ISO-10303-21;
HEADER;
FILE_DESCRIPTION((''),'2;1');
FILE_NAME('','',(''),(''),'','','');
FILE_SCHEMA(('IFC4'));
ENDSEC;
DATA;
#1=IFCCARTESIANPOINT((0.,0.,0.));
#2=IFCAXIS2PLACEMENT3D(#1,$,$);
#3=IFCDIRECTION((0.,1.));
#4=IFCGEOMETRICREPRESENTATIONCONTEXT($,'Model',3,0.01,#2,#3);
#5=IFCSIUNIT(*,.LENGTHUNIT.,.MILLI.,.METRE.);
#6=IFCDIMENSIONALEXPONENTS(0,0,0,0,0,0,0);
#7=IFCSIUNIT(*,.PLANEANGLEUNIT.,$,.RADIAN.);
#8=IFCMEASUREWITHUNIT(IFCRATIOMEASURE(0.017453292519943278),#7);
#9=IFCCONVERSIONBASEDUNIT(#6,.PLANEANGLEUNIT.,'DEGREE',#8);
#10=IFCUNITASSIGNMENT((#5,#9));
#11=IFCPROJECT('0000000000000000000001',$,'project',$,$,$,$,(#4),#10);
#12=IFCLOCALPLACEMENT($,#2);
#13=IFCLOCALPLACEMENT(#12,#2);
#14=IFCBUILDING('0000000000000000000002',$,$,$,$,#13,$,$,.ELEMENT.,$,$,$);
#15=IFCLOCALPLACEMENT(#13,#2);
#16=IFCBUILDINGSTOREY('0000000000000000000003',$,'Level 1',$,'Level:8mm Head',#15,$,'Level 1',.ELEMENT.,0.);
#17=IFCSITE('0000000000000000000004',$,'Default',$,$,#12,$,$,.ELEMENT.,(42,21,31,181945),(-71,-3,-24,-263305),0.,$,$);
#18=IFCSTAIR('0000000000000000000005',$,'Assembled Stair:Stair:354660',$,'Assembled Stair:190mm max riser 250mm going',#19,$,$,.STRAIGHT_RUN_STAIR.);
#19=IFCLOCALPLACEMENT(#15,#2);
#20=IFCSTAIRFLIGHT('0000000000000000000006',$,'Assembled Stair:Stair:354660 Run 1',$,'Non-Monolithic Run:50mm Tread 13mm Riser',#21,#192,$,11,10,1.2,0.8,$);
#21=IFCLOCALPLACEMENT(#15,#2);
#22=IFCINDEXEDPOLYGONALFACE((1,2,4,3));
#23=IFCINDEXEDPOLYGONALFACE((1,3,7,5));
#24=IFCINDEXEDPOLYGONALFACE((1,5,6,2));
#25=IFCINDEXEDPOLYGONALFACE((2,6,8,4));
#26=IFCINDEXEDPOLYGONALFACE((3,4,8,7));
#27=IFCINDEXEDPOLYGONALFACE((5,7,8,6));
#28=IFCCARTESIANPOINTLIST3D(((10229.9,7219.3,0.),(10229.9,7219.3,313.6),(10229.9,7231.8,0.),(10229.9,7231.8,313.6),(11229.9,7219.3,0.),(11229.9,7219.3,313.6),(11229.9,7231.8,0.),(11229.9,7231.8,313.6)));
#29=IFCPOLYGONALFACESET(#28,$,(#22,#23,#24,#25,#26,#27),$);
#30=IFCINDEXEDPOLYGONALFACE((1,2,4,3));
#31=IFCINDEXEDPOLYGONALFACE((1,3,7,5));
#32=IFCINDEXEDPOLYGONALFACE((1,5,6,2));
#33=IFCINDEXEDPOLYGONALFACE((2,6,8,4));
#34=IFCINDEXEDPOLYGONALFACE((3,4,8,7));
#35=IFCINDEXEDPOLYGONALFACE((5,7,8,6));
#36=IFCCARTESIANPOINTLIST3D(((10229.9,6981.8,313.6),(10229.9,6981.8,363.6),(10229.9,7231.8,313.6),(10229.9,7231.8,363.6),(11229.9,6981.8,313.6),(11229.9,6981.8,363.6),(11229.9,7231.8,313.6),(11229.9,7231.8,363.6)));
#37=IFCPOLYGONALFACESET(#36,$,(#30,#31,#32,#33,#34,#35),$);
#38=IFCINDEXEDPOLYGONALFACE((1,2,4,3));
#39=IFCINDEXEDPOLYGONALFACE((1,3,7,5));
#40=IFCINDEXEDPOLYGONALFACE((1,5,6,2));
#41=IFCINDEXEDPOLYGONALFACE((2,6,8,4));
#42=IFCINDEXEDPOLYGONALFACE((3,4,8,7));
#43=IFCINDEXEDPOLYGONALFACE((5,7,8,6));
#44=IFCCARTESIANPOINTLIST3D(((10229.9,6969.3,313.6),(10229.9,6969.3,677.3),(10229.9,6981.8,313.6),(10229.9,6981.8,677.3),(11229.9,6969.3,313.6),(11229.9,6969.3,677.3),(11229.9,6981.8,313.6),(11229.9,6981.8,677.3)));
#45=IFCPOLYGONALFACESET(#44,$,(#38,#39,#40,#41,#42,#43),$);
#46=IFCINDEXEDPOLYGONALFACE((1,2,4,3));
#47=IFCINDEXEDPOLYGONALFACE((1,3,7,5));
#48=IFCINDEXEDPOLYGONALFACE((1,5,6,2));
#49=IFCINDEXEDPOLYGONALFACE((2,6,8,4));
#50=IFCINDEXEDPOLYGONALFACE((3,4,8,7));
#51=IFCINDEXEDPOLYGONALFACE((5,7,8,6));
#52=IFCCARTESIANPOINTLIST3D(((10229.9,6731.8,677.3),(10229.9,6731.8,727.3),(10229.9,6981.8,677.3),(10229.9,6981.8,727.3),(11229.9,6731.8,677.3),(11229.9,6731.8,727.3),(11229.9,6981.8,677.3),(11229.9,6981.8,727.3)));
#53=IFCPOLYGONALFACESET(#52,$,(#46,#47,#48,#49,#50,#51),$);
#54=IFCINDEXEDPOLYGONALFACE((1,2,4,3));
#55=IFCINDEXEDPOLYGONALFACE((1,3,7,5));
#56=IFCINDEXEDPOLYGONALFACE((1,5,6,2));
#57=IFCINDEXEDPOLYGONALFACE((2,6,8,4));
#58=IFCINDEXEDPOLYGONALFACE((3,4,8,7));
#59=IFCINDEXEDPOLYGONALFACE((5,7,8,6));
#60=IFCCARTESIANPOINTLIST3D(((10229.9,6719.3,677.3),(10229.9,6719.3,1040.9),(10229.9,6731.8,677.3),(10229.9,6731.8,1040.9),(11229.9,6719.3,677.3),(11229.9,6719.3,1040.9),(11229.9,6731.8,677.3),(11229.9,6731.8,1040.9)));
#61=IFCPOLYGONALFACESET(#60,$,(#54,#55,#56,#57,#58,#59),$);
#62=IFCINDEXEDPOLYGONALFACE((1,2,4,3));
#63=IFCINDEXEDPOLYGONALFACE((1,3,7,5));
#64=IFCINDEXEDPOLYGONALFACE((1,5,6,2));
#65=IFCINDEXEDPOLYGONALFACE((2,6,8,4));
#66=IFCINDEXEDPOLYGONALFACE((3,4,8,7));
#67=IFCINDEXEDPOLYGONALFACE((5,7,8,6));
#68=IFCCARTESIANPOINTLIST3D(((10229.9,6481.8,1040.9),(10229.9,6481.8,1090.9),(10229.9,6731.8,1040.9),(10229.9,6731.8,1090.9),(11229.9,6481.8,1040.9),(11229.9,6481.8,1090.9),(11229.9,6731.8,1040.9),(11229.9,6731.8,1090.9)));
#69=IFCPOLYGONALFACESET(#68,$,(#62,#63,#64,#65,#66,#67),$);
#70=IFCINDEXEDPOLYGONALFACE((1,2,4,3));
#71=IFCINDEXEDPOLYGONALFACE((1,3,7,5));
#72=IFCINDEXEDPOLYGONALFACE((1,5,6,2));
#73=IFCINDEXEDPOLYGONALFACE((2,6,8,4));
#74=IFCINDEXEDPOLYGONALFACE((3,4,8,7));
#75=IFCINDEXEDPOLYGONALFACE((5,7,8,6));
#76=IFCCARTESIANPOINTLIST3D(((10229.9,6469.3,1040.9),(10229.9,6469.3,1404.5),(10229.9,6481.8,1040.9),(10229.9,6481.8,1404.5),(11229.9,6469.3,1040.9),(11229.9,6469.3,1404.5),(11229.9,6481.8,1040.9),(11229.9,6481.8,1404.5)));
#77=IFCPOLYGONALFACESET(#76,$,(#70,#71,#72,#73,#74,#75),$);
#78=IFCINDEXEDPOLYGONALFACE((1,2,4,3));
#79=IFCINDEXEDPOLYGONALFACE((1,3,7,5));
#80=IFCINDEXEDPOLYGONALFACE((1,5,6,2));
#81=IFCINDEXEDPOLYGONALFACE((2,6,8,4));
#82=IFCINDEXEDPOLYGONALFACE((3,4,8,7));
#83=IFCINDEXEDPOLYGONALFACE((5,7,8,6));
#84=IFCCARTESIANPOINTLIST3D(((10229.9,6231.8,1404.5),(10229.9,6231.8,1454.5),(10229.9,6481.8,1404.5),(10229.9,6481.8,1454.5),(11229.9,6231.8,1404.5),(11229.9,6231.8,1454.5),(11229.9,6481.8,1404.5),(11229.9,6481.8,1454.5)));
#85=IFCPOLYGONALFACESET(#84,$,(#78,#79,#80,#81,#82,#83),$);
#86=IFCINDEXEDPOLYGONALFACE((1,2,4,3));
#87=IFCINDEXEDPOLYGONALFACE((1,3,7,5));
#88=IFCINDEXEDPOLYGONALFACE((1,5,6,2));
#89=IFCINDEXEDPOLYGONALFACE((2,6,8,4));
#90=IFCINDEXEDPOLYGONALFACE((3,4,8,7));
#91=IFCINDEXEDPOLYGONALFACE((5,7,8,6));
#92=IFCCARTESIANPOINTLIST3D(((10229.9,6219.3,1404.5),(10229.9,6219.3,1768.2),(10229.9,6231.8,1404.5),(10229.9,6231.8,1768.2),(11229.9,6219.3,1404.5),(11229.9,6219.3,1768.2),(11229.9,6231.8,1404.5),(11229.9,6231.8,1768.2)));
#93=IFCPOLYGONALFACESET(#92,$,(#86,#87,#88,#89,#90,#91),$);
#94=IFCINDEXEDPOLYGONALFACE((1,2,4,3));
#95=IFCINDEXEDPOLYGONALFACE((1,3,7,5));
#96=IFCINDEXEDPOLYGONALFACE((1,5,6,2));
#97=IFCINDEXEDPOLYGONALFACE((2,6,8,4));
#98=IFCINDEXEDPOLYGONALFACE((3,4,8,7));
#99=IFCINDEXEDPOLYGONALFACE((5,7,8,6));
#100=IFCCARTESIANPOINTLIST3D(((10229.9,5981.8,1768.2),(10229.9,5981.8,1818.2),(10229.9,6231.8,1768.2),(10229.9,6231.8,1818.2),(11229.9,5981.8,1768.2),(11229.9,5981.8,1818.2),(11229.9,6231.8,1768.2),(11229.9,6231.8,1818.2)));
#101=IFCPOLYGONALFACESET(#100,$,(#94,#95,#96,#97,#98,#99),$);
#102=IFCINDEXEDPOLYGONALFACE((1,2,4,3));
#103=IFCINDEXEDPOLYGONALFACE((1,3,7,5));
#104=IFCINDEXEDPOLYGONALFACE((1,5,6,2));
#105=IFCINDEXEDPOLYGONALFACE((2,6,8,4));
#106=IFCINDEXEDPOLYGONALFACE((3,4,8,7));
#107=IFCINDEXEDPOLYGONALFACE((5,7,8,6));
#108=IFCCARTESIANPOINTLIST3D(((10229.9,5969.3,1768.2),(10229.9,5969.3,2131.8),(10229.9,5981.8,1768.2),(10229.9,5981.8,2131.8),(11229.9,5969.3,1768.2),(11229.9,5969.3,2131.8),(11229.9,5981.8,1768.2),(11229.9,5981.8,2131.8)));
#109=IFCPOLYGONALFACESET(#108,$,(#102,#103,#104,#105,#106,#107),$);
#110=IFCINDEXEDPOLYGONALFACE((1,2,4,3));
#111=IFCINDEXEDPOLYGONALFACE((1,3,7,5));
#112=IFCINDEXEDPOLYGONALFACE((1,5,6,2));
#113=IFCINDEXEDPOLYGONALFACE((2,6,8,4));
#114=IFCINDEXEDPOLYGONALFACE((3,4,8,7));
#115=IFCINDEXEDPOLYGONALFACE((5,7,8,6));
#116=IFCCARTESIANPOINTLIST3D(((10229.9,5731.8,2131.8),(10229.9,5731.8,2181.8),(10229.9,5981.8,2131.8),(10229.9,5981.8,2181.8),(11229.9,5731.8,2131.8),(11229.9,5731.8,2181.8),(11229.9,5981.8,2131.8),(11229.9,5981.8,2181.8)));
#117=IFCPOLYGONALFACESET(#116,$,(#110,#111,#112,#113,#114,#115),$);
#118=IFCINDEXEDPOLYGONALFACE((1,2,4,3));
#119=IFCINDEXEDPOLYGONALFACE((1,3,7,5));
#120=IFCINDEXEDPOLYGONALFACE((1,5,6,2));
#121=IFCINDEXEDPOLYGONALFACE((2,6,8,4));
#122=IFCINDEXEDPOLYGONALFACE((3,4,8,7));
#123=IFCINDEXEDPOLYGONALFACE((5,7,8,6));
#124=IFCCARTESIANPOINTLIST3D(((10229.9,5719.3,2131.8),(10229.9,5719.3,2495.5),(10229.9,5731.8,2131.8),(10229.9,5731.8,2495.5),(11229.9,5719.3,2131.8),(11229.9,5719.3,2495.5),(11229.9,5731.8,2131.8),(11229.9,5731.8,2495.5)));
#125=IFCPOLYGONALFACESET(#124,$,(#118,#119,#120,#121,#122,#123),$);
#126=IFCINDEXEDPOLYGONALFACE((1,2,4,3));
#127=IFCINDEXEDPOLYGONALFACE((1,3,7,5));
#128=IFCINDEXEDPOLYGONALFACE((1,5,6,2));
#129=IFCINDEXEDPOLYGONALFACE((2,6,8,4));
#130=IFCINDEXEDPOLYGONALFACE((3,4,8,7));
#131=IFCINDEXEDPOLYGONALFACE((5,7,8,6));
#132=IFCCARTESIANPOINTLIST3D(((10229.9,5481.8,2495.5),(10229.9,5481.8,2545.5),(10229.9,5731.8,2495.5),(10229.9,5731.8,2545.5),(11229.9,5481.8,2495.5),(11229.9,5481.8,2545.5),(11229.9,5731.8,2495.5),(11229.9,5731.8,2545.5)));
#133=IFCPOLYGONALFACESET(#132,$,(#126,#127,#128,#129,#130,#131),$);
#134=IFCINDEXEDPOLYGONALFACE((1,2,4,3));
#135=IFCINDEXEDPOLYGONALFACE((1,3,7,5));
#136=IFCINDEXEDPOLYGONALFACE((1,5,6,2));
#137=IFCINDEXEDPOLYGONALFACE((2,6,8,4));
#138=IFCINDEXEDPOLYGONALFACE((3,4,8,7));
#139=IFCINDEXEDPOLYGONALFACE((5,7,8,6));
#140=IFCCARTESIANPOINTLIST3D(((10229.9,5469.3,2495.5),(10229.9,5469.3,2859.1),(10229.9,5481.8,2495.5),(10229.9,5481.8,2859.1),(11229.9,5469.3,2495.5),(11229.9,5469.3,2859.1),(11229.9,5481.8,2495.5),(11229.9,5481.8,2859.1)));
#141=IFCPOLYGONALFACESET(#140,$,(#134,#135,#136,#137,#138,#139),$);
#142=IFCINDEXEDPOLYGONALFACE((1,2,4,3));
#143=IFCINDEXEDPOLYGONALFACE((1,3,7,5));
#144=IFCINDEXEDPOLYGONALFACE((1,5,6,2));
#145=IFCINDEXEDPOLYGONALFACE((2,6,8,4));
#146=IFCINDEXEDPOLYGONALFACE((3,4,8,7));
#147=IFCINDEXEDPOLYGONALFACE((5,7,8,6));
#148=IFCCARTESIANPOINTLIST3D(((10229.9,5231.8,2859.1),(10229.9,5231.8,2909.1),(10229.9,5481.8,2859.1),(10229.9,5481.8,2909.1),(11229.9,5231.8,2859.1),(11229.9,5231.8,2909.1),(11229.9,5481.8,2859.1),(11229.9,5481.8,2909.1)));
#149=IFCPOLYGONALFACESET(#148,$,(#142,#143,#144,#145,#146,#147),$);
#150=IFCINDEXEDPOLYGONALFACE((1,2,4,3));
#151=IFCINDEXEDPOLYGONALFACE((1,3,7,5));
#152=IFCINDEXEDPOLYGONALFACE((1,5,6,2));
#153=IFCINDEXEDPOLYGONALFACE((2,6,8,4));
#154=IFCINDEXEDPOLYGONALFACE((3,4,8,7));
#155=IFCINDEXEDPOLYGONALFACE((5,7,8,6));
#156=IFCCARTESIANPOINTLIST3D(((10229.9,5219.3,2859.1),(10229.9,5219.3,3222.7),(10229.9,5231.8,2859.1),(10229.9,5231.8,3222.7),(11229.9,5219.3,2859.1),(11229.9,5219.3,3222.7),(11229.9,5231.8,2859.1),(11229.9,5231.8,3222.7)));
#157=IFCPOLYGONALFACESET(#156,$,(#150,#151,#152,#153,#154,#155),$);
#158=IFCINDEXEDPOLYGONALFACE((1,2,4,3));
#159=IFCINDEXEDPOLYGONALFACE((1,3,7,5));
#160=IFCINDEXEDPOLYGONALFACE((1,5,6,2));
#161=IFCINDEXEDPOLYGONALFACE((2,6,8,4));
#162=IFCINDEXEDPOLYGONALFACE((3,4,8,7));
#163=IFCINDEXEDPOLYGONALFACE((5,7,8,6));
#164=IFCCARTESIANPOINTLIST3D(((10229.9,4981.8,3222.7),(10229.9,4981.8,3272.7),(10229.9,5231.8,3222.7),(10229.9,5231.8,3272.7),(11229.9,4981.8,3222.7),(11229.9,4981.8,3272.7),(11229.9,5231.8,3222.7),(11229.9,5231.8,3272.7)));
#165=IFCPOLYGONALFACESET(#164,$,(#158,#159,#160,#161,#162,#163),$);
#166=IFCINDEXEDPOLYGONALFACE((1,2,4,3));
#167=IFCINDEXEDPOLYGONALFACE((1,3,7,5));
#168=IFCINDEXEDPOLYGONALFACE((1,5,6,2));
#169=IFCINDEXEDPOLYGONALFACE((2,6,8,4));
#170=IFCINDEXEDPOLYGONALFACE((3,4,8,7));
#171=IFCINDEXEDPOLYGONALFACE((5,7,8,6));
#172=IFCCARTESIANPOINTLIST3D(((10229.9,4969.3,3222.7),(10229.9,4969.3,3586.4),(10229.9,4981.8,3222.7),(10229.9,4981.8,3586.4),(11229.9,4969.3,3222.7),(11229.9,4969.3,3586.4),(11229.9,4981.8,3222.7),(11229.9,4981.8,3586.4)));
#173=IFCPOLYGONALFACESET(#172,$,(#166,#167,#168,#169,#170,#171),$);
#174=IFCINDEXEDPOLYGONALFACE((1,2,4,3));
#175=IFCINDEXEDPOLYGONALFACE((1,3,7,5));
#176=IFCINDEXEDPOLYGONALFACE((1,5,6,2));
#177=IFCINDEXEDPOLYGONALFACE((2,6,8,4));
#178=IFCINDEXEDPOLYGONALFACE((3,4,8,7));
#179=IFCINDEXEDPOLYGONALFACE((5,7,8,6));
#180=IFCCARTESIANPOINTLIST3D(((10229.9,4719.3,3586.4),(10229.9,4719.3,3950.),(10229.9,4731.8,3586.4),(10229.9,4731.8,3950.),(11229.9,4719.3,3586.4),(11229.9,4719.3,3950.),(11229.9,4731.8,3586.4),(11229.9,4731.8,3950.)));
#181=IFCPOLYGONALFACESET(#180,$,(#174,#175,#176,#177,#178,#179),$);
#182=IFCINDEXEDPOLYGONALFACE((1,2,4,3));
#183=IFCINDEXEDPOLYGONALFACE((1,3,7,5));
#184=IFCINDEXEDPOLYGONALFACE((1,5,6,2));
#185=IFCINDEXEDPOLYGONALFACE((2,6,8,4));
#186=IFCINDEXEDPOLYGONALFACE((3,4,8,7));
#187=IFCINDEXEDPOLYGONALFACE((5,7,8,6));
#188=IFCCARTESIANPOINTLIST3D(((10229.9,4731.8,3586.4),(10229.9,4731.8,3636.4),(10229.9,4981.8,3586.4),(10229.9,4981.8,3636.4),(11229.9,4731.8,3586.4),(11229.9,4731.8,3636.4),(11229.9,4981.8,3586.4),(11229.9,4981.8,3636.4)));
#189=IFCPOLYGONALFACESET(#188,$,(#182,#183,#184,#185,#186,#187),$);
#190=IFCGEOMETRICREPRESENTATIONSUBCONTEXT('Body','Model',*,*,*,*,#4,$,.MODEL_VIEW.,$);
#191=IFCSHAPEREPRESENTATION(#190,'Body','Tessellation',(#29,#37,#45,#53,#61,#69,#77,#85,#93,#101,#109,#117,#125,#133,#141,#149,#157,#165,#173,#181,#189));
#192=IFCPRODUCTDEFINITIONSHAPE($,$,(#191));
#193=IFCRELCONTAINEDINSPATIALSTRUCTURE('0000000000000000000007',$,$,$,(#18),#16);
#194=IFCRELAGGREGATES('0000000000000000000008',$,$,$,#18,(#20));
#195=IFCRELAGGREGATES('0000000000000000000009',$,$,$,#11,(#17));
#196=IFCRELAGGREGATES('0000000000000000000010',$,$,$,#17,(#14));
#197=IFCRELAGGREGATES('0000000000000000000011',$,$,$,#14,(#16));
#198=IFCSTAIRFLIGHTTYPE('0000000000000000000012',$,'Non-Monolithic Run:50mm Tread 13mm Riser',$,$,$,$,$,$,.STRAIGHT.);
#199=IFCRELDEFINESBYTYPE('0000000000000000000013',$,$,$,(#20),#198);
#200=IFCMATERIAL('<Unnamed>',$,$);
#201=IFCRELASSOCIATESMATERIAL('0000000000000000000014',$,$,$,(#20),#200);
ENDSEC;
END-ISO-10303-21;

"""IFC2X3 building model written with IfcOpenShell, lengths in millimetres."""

from ifc_helpers import new_model, entity, si_unit, converted_unit, direction, frame, frame_2d, origin, origin_2d_with_axis, place, context, subcontext, project, spatial, rectangle, extrude, material, type_object, element, aggregate, save


model = new_model("IFC2X3")

# Units and contexts
model_context = context("Model", 3, precision=0.01, world=origin(), true_north=direction((0.0, 1.0)))
body_context = subcontext(model_context, "Body", "Model", "MODEL_VIEW")
ifc_project = project(units=[si_unit("LENGTHUNIT", "METRE", prefix="MILLI"), converted_unit("PLANEANGLEUNIT", "DEGREE", entity("IfcRatioMeasure", 0.017453292519943278), si_unit("PLANEANGLEUNIT", "RADIAN"), dimensions=[0, 0, 0, 0, 0, 0, 0])], contexts=[model_context])

# Site, building, storey
site_placement = place(None, origin())
site = spatial("IfcSite", under=ifc_project, at=site_placement, Name="Default", CompositionType="ELEMENT", RefLatitude=(42, 21, 31, 181945), RefLongitude=(-71, -3, -24, -263305), RefElevation=0.0)
building_placement = place(site_placement, origin())
building = spatial("IfcBuilding", under=site, at=building_placement, CompositionType="ELEMENT")
storey_placement = place(building_placement, origin())
storey = spatial("IfcBuildingStorey", under=building, at=storey_placement, Name="Level 1", ObjectType="Level:8mm Head", LongName="Level 1", CompositionType="ELEMENT", Elevation=0.0)

# Stair
stair_placement = place(storey_placement, origin())
stair = element("IfcStair", 1, at=stair_placement, inside=storey, Name="Assembled Stair:Stair:354660", ObjectType="Assembled Stair:190mm max riser 250mm going", ShapeType="STRAIGHT_RUN_STAIR")
ifc_material_1 = material(Name="<Unnamed>")

# Stair flight
stair_flight_type = type_object("IfcStairFlightType", Name="Non-Monolithic Run:50mm Tread 13mm Riser", PredefinedType="STRAIGHT")
stair_flight_placement = place(stair_placement, origin())
stair_flight = element("IfcStairFlight", 2, at=stair_flight_placement, type_object=stair_flight_type, material=ifc_material_1, Name="Assembled Stair:Stair:354660 Run 1", ObjectType="Non-Monolithic Run:50mm Tread 13mm Riser", NumberOfRiser=11, NumberOfTreads=10, RiserHeight=1.2, TreadLength=0.8, context=body_context, shape_type="SweptSolid", body=[
    extrude(rectangle(XDim=1000.0, YDim=12.5, at=frame_2d((0.0, 0.0), x_axis=(1.0, 0.0))), frame((10729.9, 7225.6, 0.0)), (0.0, 0.0, 1.0), 313.6),
    extrude(rectangle(XDim=250.0, YDim=1000.0, at=origin_2d_with_axis()), frame((10729.9, 7106.8, 313.6), z_axis=(0.0, 0.0, 1.0), x_axis=(0.0, 1.0, 0.0)), (0.0, 0.0, 1.0), 50.0),
    extrude(rectangle(XDim=1000.0, YDim=12.5, at=frame_2d((0.0, 0.0), x_axis=(1.0, 0.0))), frame((10729.9, 6975.6, 313.6)), (0.0, 0.0, 1.0), 363.6),
    extrude(rectangle(XDim=250.0, YDim=1000.0, at=frame_2d((0.0, 0.0), x_axis=(1.0, 0.0))), frame((10729.9, 6856.8, 677.3), z_axis=(0.0, 0.0, 1.0), x_axis=(0.0, 1.0, 0.0)), (0.0, 0.0, 1.0), 50.0),
    extrude(rectangle(XDim=1000.0, YDim=12.5, at=frame_2d((0.0, 0.0), x_axis=(1.0, 0.0))), frame((10729.9, 6725.6, 677.3)), (0.0, 0.0, 1.0), 363.6),
    extrude(rectangle(XDim=250.0, YDim=1000.0, at=frame_2d((0.0, 0.0), x_axis=(1.0, 0.0))), frame((10729.9, 6606.8, 1040.9), z_axis=(0.0, 0.0, 1.0), x_axis=(0.0, 1.0, 0.0)), (0.0, 0.0, 1.0), 50.0),
    extrude(rectangle(XDim=1000.0, YDim=12.5, at=frame_2d((0.0, 0.0), x_axis=(1.0, 0.0))), frame((10729.9, 6475.6, 1040.9)), (0.0, 0.0, 1.0), 363.6),
    extrude(rectangle(XDim=250.0, YDim=1000.0, at=frame_2d((0.0, 0.0), x_axis=(1.0, 0.0))), frame((10729.9, 6356.8, 1404.5), z_axis=(0.0, 0.0, 1.0), x_axis=(0.0, 1.0, 0.0)), (0.0, 0.0, 1.0), 50.0),
    extrude(rectangle(XDim=1000.0, YDim=12.5, at=frame_2d((0.0, 0.0), x_axis=(1.0, 0.0))), frame((10729.9, 6225.6, 1404.5)), (0.0, 0.0, 1.0), 363.6),
    extrude(rectangle(XDim=250.0, YDim=1000.0, at=frame_2d((0.0, 0.0), x_axis=(1.0, 0.0))), frame((10729.9, 6106.8, 1768.2), z_axis=(0.0, 0.0, 1.0), x_axis=(0.0, 1.0, 0.0)), (0.0, 0.0, 1.0), 50.0),
    extrude(rectangle(XDim=1000.0, YDim=12.5, at=frame_2d((0.0, 0.0), x_axis=(1.0, 0.0))), frame((10729.9, 5975.6, 1768.2)), (0.0, 0.0, 1.0), 363.6),
    extrude(rectangle(XDim=250.0, YDim=1000.0, at=frame_2d((0.0, 0.0), x_axis=(1.0, 0.0))), frame((10729.9, 5856.8, 2131.8), z_axis=(0.0, 0.0, 1.0), x_axis=(0.0, 1.0, 0.0)), (0.0, 0.0, 1.0), 50.0),
    extrude(rectangle(XDim=1000.0, YDim=12.5, at=frame_2d((0.0, 0.0), x_axis=(1.0, 0.0))), frame((10729.9, 5725.6, 2131.8)), (0.0, 0.0, 1.0), 363.6),
    extrude(rectangle(XDim=250.0, YDim=1000.0, at=frame_2d((0.0, 0.0), x_axis=(1.0, 0.0))), frame((10729.9, 5606.8, 2495.5), z_axis=(0.0, 0.0, 1.0), x_axis=(0.0, 1.0, 0.0)), (0.0, 0.0, 1.0), 50.0),
    extrude(rectangle(XDim=1000.0, YDim=12.5, at=frame_2d((0.0, 0.0), x_axis=(1.0, 0.0))), frame((10729.9, 5475.6, 2495.5)), (0.0, 0.0, 1.0), 363.6),
    extrude(rectangle(XDim=250.0, YDim=1000.0, at=frame_2d((0.0, 0.0), x_axis=(1.0, 0.0))), frame((10729.9, 5356.8, 2859.1), z_axis=(0.0, 0.0, 1.0), x_axis=(0.0, 1.0, 0.0)), (0.0, 0.0, 1.0), 50.0),
    extrude(rectangle(XDim=1000.0, YDim=12.5, at=frame_2d((0.0, 0.0), x_axis=(1.0, 0.0))), frame((10729.9, 5225.6, 2859.1)), (0.0, 0.0, 1.0), 363.6),
    extrude(rectangle(XDim=250.0, YDim=1000.0, at=frame_2d((0.0, 0.0), x_axis=(1.0, 0.0))), frame((10729.9, 5106.8, 3222.7), z_axis=(0.0, 0.0, 1.0), x_axis=(0.0, 1.0, 0.0)), (0.0, 0.0, 1.0), 50.0),
    extrude(rectangle(XDim=1000.0, YDim=12.5, at=frame_2d((0.0, 0.0), x_axis=(1.0, 0.0))), frame((10729.9, 4975.6, 3222.7)), (0.0, 0.0, 1.0), 363.6),
    extrude(rectangle(XDim=1000.0, YDim=12.5, at=frame_2d((0.0, 0.0), x_axis=(1.0, 0.0))), frame((10729.9, 4725.6, 3586.4)), (0.0, 0.0, 1.0), 363.6),
    extrude(rectangle(XDim=250.0, YDim=1000.0, at=origin_2d_with_axis()), frame((10729.9, 4856.8, 3586.4), z_axis=(0.0, 0.0, 1.0), x_axis=(0.0, 1.0, 0.0)), (0.0, 0.0, 1.0), 50.0),
])

aggregate(stair, [stair_flight])

save(model, "model.ifc")
